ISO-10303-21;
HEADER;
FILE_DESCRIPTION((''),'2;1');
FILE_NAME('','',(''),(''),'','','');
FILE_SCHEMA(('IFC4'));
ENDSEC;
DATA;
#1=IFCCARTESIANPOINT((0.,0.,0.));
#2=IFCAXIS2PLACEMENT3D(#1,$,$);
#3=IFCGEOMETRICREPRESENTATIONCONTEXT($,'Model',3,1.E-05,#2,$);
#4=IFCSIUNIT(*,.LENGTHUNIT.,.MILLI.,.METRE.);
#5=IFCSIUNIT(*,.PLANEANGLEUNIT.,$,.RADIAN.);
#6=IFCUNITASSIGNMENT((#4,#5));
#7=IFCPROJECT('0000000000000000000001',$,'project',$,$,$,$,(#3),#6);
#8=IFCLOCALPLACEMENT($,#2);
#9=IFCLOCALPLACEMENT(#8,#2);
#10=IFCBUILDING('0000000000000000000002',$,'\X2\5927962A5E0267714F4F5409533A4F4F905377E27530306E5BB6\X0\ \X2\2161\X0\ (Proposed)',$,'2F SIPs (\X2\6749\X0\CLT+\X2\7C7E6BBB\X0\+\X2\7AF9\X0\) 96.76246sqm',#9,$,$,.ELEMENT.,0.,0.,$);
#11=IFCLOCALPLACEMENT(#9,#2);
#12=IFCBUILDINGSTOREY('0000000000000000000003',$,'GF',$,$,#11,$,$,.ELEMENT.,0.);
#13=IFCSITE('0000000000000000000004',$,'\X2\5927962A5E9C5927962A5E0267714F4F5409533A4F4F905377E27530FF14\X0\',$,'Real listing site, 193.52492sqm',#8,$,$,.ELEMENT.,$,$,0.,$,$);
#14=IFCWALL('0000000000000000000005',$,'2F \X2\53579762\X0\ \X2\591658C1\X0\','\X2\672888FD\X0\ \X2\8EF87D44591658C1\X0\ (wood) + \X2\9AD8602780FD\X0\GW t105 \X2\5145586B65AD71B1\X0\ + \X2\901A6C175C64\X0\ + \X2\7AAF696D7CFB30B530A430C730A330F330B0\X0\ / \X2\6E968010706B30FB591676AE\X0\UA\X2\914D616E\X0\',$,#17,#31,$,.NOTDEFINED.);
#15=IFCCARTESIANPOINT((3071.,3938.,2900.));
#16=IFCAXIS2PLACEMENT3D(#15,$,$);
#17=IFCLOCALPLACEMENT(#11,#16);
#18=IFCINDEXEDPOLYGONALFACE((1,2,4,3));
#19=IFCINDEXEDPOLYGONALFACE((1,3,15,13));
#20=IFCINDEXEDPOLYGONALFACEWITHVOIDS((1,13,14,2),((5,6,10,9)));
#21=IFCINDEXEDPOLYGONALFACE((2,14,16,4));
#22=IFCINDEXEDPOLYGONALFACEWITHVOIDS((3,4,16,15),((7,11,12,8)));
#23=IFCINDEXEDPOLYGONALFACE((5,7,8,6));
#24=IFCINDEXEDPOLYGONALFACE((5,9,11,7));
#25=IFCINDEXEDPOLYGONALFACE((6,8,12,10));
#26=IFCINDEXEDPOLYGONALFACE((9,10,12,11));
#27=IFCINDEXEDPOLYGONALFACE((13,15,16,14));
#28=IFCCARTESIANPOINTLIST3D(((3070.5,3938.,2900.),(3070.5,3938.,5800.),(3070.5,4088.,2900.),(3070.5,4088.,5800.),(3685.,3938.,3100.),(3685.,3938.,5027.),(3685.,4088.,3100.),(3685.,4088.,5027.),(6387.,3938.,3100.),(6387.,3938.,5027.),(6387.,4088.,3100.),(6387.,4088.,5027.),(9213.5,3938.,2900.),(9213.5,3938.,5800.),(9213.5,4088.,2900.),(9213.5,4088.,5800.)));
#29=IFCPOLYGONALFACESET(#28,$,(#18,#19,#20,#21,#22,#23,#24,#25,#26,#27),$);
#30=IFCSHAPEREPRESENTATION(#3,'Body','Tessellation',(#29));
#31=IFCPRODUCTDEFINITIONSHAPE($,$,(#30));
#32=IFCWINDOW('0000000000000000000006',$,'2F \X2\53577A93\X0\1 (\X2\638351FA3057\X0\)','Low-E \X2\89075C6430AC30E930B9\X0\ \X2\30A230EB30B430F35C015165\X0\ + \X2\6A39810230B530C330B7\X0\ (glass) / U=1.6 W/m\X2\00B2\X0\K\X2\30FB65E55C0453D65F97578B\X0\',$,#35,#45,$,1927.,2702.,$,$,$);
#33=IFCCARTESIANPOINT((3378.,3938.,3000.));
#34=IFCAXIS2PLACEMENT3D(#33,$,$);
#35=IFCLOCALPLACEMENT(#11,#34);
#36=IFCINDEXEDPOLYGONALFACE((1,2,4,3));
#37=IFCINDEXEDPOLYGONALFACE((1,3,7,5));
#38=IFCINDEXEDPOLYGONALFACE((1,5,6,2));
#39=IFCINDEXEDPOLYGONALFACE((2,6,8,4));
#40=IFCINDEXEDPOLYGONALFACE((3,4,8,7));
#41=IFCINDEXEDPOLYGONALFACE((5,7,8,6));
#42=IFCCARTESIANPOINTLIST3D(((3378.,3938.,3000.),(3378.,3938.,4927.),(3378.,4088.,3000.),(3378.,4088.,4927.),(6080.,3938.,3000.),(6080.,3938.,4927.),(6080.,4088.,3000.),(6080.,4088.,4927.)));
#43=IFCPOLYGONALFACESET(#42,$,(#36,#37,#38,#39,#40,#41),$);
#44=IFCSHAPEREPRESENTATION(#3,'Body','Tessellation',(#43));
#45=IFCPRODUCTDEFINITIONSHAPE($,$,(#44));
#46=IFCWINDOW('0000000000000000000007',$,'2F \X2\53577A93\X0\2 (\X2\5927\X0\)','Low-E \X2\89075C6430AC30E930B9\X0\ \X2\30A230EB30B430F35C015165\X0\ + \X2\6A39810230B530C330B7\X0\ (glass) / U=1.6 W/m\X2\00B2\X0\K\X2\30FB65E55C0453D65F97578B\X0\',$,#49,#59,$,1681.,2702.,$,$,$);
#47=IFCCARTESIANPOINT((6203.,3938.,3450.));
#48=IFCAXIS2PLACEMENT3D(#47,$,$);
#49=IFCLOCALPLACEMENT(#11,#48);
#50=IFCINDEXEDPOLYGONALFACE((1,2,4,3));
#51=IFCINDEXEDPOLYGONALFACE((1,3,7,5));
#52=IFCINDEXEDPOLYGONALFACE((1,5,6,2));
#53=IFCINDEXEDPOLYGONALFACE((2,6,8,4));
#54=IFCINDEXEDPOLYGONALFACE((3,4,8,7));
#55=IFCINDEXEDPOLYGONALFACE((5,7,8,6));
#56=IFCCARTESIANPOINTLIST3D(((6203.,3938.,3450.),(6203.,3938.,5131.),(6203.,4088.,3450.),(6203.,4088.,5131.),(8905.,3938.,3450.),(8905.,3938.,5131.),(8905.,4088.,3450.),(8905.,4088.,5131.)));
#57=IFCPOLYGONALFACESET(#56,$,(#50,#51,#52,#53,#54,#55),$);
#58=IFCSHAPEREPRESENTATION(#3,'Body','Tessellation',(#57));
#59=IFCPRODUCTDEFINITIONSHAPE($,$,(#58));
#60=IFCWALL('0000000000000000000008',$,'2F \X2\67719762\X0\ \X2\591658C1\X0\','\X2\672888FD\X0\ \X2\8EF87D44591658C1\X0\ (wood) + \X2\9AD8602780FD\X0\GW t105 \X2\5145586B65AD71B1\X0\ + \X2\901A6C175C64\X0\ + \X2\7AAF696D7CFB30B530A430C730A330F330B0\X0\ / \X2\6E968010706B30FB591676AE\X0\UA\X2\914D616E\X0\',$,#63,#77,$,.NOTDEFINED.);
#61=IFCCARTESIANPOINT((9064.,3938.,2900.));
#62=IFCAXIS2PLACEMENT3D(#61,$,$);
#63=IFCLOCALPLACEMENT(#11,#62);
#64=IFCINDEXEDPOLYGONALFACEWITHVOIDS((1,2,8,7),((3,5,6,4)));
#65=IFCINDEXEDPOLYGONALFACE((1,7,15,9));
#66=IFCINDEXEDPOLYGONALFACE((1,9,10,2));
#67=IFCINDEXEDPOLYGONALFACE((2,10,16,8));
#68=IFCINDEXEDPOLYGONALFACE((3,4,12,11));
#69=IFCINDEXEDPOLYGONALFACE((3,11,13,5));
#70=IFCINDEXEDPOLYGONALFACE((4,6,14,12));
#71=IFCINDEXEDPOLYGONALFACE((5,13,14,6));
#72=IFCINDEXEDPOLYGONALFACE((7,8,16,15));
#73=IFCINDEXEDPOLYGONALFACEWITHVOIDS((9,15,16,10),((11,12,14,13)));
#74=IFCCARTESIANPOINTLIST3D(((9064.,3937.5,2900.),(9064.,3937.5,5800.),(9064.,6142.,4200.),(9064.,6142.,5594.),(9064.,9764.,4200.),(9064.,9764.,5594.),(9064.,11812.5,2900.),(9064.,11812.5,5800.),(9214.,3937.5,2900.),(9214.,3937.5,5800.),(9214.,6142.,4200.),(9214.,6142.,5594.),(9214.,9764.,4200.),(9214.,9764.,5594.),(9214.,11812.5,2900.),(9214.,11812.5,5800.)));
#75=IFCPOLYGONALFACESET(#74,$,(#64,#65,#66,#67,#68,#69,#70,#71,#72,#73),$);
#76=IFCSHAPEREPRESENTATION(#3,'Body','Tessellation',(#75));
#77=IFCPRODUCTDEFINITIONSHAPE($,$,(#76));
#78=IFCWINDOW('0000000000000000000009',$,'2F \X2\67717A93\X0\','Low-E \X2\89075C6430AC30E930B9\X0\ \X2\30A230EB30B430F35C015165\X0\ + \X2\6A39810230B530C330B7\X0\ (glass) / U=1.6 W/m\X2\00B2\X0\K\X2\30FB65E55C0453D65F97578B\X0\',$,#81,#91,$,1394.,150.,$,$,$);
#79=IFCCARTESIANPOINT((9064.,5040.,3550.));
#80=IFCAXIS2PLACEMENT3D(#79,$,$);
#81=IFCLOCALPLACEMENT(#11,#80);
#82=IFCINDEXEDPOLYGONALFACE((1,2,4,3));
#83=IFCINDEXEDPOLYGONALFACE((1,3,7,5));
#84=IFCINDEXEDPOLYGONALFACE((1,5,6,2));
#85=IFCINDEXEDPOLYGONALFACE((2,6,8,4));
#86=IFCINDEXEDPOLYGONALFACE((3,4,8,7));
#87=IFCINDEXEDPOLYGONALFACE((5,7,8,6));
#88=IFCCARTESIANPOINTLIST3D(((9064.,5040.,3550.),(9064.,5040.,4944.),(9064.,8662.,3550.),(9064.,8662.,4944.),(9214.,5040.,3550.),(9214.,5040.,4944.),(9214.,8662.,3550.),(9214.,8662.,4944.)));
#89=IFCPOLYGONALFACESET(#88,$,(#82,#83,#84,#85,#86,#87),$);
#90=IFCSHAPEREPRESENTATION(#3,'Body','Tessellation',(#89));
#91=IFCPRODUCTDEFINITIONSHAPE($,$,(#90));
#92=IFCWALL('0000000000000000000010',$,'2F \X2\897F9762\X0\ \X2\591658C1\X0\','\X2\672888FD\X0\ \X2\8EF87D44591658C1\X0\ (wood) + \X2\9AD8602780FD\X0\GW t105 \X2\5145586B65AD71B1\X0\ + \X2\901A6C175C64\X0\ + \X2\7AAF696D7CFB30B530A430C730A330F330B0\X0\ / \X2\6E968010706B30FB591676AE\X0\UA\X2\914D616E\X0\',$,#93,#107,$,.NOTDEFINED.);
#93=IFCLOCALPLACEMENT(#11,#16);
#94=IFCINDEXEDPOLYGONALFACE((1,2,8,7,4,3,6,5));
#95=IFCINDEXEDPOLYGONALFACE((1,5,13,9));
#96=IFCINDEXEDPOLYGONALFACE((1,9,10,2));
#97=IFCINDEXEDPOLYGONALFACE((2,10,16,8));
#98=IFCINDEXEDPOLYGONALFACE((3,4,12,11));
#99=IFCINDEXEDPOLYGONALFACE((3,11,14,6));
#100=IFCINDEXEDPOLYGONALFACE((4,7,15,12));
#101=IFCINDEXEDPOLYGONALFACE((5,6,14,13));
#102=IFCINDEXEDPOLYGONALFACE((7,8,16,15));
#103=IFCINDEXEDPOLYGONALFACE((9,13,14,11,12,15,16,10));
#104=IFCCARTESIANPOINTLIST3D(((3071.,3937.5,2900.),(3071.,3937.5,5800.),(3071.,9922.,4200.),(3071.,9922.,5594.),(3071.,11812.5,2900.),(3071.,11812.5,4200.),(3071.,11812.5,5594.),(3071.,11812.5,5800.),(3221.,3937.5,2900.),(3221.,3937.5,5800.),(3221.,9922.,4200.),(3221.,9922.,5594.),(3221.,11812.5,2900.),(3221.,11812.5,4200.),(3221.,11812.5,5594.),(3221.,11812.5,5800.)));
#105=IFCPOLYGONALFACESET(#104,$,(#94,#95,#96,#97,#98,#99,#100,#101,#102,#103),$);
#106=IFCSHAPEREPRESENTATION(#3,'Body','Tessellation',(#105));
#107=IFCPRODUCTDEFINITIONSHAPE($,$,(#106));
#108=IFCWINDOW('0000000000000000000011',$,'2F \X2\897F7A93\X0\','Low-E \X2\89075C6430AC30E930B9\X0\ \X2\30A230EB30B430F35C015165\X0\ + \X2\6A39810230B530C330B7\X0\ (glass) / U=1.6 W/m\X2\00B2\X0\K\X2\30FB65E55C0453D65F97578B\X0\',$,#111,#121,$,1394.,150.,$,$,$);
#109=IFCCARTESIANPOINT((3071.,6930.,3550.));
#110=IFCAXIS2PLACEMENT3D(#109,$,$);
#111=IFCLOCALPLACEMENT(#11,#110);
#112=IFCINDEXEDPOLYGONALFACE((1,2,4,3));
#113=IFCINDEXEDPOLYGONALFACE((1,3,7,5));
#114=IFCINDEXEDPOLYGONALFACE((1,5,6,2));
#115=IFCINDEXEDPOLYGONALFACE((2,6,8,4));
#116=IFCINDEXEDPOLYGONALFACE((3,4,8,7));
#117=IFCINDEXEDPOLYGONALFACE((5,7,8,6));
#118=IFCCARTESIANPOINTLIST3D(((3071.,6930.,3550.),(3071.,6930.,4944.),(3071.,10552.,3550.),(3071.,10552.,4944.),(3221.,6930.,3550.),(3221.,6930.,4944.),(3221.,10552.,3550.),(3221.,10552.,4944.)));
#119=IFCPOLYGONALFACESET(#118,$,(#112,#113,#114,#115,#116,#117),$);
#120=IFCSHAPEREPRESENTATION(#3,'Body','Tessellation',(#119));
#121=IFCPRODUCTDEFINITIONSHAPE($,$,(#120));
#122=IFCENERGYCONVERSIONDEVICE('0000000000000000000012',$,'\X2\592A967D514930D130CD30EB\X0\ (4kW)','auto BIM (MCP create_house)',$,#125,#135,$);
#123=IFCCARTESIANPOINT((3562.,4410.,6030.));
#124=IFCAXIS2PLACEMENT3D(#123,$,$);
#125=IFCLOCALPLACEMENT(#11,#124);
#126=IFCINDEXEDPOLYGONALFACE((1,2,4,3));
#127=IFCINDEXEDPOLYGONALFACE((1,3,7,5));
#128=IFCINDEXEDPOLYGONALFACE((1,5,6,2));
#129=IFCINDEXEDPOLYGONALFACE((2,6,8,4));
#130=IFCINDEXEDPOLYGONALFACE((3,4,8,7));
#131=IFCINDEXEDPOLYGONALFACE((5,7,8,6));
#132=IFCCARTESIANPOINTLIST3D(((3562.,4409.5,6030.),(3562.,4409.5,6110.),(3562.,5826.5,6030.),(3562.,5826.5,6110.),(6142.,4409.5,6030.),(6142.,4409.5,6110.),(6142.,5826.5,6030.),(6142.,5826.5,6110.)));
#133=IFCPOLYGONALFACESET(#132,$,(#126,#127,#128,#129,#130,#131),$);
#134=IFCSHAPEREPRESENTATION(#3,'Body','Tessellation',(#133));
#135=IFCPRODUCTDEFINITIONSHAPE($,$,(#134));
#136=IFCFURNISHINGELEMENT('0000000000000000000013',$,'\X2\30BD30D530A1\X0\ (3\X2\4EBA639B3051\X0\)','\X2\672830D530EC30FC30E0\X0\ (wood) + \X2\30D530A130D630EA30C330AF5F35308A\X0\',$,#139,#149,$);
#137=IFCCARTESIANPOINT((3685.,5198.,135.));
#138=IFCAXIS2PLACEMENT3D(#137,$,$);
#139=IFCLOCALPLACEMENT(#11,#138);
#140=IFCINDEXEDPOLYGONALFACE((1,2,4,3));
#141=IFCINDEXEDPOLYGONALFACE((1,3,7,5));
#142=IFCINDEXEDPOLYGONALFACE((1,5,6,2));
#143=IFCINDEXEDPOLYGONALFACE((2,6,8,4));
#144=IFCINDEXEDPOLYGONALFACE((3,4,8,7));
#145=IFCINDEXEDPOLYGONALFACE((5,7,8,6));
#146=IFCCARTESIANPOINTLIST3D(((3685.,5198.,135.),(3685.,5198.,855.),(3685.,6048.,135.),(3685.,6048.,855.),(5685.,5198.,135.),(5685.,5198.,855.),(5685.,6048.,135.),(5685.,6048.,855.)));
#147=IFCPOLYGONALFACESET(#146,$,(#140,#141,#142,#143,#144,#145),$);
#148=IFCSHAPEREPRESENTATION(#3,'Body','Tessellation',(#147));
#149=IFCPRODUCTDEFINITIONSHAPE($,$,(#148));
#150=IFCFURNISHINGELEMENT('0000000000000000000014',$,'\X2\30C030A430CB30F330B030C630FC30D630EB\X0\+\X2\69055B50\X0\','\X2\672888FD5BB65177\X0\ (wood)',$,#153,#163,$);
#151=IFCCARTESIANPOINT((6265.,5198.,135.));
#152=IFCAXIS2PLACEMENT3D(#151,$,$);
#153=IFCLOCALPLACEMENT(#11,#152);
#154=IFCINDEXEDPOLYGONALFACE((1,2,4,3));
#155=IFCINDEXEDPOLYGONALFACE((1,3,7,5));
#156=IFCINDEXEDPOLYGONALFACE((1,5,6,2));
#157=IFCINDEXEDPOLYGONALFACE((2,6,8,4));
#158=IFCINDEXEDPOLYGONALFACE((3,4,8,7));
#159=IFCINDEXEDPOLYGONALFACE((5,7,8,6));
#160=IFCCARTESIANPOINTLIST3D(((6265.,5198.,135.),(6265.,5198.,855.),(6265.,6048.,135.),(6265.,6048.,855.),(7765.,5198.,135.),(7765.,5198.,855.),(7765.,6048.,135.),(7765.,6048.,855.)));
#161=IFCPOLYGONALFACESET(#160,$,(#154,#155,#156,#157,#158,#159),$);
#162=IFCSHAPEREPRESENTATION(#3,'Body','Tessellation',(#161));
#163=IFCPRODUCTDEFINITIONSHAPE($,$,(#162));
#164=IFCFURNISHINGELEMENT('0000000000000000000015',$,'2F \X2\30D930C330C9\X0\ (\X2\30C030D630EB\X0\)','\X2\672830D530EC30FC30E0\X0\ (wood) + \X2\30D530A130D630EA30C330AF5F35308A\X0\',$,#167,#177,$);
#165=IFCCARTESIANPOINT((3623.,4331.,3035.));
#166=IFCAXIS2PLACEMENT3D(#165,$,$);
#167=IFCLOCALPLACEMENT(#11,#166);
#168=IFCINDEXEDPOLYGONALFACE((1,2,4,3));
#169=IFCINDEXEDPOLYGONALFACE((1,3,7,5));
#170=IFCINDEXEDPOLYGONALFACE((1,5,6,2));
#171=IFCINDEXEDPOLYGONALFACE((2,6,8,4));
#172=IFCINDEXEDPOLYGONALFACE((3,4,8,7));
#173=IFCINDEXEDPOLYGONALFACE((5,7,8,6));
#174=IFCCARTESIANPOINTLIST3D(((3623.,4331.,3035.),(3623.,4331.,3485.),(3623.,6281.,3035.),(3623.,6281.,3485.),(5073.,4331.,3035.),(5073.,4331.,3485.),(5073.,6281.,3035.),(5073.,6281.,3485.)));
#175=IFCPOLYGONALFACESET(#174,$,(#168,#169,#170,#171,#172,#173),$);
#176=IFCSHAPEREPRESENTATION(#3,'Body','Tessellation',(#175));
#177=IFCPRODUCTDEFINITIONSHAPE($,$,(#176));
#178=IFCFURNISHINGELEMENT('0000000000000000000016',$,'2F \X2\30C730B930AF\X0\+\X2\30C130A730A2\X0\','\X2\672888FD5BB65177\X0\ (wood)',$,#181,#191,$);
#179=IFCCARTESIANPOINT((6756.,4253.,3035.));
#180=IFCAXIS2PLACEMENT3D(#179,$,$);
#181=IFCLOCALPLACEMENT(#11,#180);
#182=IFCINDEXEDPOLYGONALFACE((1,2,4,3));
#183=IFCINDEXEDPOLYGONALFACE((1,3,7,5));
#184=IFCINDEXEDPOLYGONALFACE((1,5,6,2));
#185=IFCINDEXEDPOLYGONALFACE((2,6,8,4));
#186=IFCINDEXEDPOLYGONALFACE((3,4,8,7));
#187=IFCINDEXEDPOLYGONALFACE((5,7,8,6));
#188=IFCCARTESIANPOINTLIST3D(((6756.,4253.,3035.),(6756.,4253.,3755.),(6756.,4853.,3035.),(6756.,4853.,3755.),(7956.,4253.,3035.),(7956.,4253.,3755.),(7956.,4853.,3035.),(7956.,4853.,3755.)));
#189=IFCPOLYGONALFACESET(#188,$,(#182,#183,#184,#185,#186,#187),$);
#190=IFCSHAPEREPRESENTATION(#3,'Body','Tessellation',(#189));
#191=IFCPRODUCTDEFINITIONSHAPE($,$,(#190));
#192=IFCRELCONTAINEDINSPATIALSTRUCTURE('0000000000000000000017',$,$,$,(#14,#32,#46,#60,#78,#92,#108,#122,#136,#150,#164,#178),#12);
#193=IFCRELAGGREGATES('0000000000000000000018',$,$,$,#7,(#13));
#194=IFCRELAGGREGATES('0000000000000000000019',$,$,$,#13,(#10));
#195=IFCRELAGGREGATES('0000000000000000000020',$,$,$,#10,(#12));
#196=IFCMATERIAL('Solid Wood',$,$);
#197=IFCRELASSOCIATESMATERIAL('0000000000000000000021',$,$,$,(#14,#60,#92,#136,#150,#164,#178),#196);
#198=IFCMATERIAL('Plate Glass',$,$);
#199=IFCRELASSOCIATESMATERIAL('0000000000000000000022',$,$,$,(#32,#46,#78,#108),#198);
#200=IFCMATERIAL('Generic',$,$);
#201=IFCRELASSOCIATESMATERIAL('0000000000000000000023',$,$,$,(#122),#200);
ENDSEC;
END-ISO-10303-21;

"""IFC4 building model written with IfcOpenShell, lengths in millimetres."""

from ifc_helpers import new_model, si_unit, frame, frame_2d, origin, place, context, project, spatial, rectangle, extrude, material, element, fill, save


model = new_model("IFC4")

# Units and contexts
model_context = context("Model", 3, precision=1e-05, world=origin())
ifc_project = project(units=[si_unit("LENGTHUNIT", "METRE", prefix="MILLI"), si_unit("PLANEANGLEUNIT", "RADIAN")], contexts=[model_context])

# Site, building, storey
site_placement = place(None, origin())
site = spatial("IfcSite", under=ifc_project, at=site_placement, Name="大阪府大阪市東住吉区住道矢田４", ObjectType="Real listing site, 193.52492sqm", CompositionType="ELEMENT", RefElevation=0.0)
building_placement = place(site_placement, origin())
building = spatial("IfcBuilding", under=site, at=building_placement, Name="大阪市東住吉区住道矢田の家 Ⅱ (Proposed)", ObjectType="2F SIPs (杉CLT+籾殻+竹) 96.76246sqm", CompositionType="ELEMENT", ElevationOfRefHeight=0.0, ElevationOfTerrain=0.0)
storey_placement = place(building_placement, origin())
storey = spatial("IfcBuildingStorey", under=building, at=storey_placement, Name="GF", CompositionType="ELEMENT", Elevation=0.0)

# Shared definitions
ifc_material_1 = material(Name="Solid Wood")

# Wall, openings, windows
wall_1_placement = place(storey_placement, frame((3071.0, 3938.0, 2900.0)))
wall_1 = element("IfcWall", 1, at=wall_1_placement, inside=storey, material=ifc_material_1, Name="2F 南面 外壁", Description="木製 軸組外壁 (wood) + 高性能GW t105 充填断熱 + 通気層 + 窯業系サイディング / 準耐火・外皮UA配慮", PredefinedType="NOTDEFINED", context=model_context, shape_type="SweptSolid", body=[
    extrude(rectangle(XDim=6143.0, YDim=150.0, at=frame_2d((3071.0, 75.0))), frame((3071.0, 3938.0, 2900.0)), (0.0, 0.0, 1.0), 2900.0),
])
opening_1_placement = place(storey_placement, frame((3378.0, 3938.0, 3000.0)))
opening_1 = element("IfcOpeningElement", 2, at=opening_1_placement, cuts=wall_1, PredefinedType="NOTDEFINED", context=model_context, shape_type="SweptSolid", body=[
    extrude(rectangle(XDim=2702.0, YDim=150.0, at=frame_2d((1351.0, 75.0))), frame((3378.0, 3938.0, 3000.0)), (0.0, 0.0, 1.0), 1927.0),
])
opening_2_placement = place(storey_placement, frame((6203.0, 3938.0, 3450.0)))
opening_2 = element("IfcOpeningElement", 3, at=opening_2_placement, cuts=wall_1, PredefinedType="NOTDEFINED", context=model_context, shape_type="SweptSolid", body=[
    extrude(rectangle(XDim=2702.0, YDim=150.0, at=frame_2d((1351.0, 75.0))), frame((6203.0, 3938.0, 3450.0)), (0.0, 0.0, 1.0), 1681.0),
])
ifc_material_2 = material(Name="Plate Glass")
window_1_placement = place(storey_placement, frame((3378.0, 3938.0, 3000.0)))
window_1 = element("IfcWindow", 4, at=window_1_placement, inside=storey, material=ifc_material_2, Name="2F 南窓1 (掃出し)", Description="Low-E 複層ガラス アルゴン封入 + 樹脂サッシ (glass) / U=1.6 W/m²K・日射取得型", OverallHeight=1927.0, OverallWidth=2702.0, context=model_context, shape_type="SweptSolid", body=[
    extrude(rectangle(XDim=2702.0, YDim=150.0, at=frame_2d((1351.0, 75.0))), frame((3378.0, 3938.0, 3000.0)), (0.0, 0.0, 1.0), 1927.0),
])
fill(opening_1, window_1)
window_2_placement = place(storey_placement, frame((6203.0, 3938.0, 3450.0)))
window_2 = element("IfcWindow", 5, at=window_2_placement, inside=storey, material=ifc_material_2, Name="2F 南窓2 (大)", Description="Low-E 複層ガラス アルゴン封入 + 樹脂サッシ (glass) / U=1.6 W/m²K・日射取得型", OverallHeight=1681.0, OverallWidth=2702.0, context=model_context, shape_type="SweptSolid", body=[
    extrude(rectangle(XDim=2702.0, YDim=150.0, at=frame_2d((1351.0, 75.0))), frame((6203.0, 3938.0, 3450.0)), (0.0, 0.0, 1.0), 1681.0),
])
fill(opening_2, window_2)

# Walls, openings, windows
wall_2_placement = place(storey_placement, frame((9064.0, 3938.0, 2900.0)))
wall_2 = element("IfcWall", 6, at=wall_2_placement, inside=storey, material=ifc_material_1, Name="2F 東面 外壁", Description="木製 軸組外壁 (wood) + 高性能GW t105 充填断熱 + 通気層 + 窯業系サイディング / 準耐火・外皮UA配慮", PredefinedType="NOTDEFINED", context=model_context, shape_type="SweptSolid", body=[
    extrude(rectangle(XDim=150.0, YDim=7875.0, at=frame_2d((75.0, 3937.0))), frame((9064.0, 3938.0, 2900.0)), (0.0, 0.0, 1.0), 2900.0),
])
opening_3_placement = place(storey_placement, frame((9064.0, 5040.0, 3550.0)))
opening_3 = element("IfcOpeningElement", 7, at=opening_3_placement, cuts=wall_2, PredefinedType="NOTDEFINED", context=model_context, shape_type="SweptSolid", body=[
    extrude(rectangle(XDim=150.0, YDim=3622.0, at=frame_2d((75.0, 1811.0))), frame((9064.0, 5040.0, 3550.0)), (0.0, 0.0, 1.0), 1394.0),
])
window_3_placement = place(storey_placement, frame((9064.0, 5040.0, 3550.0)))
window_3 = element("IfcWindow", 8, at=window_3_placement, inside=storey, material=ifc_material_2, Name="2F 東窓", Description="Low-E 複層ガラス アルゴン封入 + 樹脂サッシ (glass) / U=1.6 W/m²K・日射取得型", OverallHeight=1394.0, OverallWidth=150.0, context=model_context, shape_type="SweptSolid", body=[
    extrude(rectangle(XDim=150.0, YDim=3622.0, at=frame_2d((75.0, 1811.0))), frame((9064.0, 5040.0, 3550.0)), (0.0, 0.0, 1.0), 1394.0),
])
fill(opening_3, window_3)
wall_3_placement = place(storey_placement, frame((3071.0, 3938.0, 2900.0)))
wall_3 = element("IfcWall", 9, at=wall_3_placement, inside=storey, material=ifc_material_1, Name="2F 西面 外壁", Description="木製 軸組外壁 (wood) + 高性能GW t105 充填断熱 + 通気層 + 窯業系サイディング / 準耐火・外皮UA配慮", PredefinedType="NOTDEFINED", context=model_context, shape_type="SweptSolid", body=[
    extrude(rectangle(XDim=150.0, YDim=7875.0, at=frame_2d((75.0, 3937.0))), frame((3071.0, 3938.0, 2900.0)), (0.0, 0.0, 1.0), 2900.0),
])
opening_4_placement = place(storey_placement, frame((3071.0, 6930.0, 3550.0)))
opening_4 = element("IfcOpeningElement", 10, at=opening_4_placement, cuts=wall_3, PredefinedType="NOTDEFINED", context=model_context, shape_type="SweptSolid", body=[
    extrude(rectangle(XDim=150.0, YDim=3622.0, at=frame_2d((75.0, 1811.0))), frame((3071.0, 6930.0, 3550.0)), (0.0, 0.0, 1.0), 1394.0),
])
window_4_placement = place(storey_placement, frame((3071.0, 6930.0, 3550.0)))
window_4 = element("IfcWindow", 11, at=window_4_placement, inside=storey, material=ifc_material_2, Name="2F 西窓", Description="Low-E 複層ガラス アルゴン封入 + 樹脂サッシ (glass) / U=1.6 W/m²K・日射取得型", OverallHeight=1394.0, OverallWidth=150.0, context=model_context, shape_type="SweptSolid", body=[
    extrude(rectangle(XDim=150.0, YDim=3622.0, at=frame_2d((75.0, 1811.0))), frame((3071.0, 6930.0, 3550.0)), (0.0, 0.0, 1.0), 1394.0),
])
fill(opening_4, window_4)

# Shared definitions
ifc_material_3 = material(Name="Generic")

# Energy conversion device
energy_conversion_device_placement = place(storey_placement, frame((3562.0, 4410.0, 6030.0)))
element("IfcEnergyConversionDevice", 12, at=energy_conversion_device_placement, inside=storey, material=ifc_material_3, Name="太陽光パネル (4kW)", Description="auto BIM (MCP create_house)", context=model_context, shape_type="SweptSolid", body=[
    extrude(rectangle(XDim=2580.0, YDim=1417.0, at=frame_2d((1290.0, 708.0))), frame((3562.0, 4410.0, 6030.0)), (0.0, 0.0, 1.0), 80.0),
])

# Furnishing elements
furnishing_1_placement = place(storey_placement, frame((3685.0, 5198.0, 135.0)))
element("IfcFurnishingElement", 13, at=furnishing_1_placement, inside=storey, material=ifc_material_1, Name="ソファ (3人掛け)", Description="木フレーム (wood) + ファブリック張り", context=model_context, shape_type="SweptSolid", body=[
    extrude(rectangle(XDim=2000.0, YDim=850.0, at=frame_2d((1000.0, 425.0))), frame((3685.0, 5198.0, 135.0)), (0.0, 0.0, 1.0), 720.0),
])
furnishing_2_placement = place(storey_placement, frame((6265.0, 5198.0, 135.0)))
element("IfcFurnishingElement", 14, at=furnishing_2_placement, inside=storey, material=ifc_material_1, Name="ダイニングテーブル+椅子", Description="木製家具 (wood)", context=model_context, shape_type="SweptSolid", body=[
    extrude(rectangle(XDim=1500.0, YDim=850.0, at=frame_2d((750.0, 425.0))), frame((6265.0, 5198.0, 135.0)), (0.0, 0.0, 1.0), 720.0),
])
furnishing_3_placement = place(storey_placement, frame((3623.0, 4331.0, 3035.0)))
element("IfcFurnishingElement", 15, at=furnishing_3_placement, inside=storey, material=ifc_material_1, Name="2F ベッド (ダブル)", Description="木フレーム (wood) + ファブリック張り", context=model_context, shape_type="SweptSolid", body=[
    extrude(rectangle(XDim=1450.0, YDim=1950.0, at=frame_2d((725.0, 975.0))), frame((3623.0, 4331.0, 3035.0)), (0.0, 0.0, 1.0), 450.0),
])
furnishing_4_placement = place(storey_placement, frame((6756.0, 4253.0, 3035.0)))
element("IfcFurnishingElement", 16, at=furnishing_4_placement, inside=storey, material=ifc_material_1, Name="2F デスク+チェア", Description="木製家具 (wood)", context=model_context, shape_type="SweptSolid", body=[
    extrude(rectangle(XDim=1200.0, YDim=600.0, at=frame_2d((600.0, 300.0))), frame((6756.0, 4253.0, 3035.0)), (0.0, 0.0, 1.0), 720.0),
])

save(model, "model.ifc")
